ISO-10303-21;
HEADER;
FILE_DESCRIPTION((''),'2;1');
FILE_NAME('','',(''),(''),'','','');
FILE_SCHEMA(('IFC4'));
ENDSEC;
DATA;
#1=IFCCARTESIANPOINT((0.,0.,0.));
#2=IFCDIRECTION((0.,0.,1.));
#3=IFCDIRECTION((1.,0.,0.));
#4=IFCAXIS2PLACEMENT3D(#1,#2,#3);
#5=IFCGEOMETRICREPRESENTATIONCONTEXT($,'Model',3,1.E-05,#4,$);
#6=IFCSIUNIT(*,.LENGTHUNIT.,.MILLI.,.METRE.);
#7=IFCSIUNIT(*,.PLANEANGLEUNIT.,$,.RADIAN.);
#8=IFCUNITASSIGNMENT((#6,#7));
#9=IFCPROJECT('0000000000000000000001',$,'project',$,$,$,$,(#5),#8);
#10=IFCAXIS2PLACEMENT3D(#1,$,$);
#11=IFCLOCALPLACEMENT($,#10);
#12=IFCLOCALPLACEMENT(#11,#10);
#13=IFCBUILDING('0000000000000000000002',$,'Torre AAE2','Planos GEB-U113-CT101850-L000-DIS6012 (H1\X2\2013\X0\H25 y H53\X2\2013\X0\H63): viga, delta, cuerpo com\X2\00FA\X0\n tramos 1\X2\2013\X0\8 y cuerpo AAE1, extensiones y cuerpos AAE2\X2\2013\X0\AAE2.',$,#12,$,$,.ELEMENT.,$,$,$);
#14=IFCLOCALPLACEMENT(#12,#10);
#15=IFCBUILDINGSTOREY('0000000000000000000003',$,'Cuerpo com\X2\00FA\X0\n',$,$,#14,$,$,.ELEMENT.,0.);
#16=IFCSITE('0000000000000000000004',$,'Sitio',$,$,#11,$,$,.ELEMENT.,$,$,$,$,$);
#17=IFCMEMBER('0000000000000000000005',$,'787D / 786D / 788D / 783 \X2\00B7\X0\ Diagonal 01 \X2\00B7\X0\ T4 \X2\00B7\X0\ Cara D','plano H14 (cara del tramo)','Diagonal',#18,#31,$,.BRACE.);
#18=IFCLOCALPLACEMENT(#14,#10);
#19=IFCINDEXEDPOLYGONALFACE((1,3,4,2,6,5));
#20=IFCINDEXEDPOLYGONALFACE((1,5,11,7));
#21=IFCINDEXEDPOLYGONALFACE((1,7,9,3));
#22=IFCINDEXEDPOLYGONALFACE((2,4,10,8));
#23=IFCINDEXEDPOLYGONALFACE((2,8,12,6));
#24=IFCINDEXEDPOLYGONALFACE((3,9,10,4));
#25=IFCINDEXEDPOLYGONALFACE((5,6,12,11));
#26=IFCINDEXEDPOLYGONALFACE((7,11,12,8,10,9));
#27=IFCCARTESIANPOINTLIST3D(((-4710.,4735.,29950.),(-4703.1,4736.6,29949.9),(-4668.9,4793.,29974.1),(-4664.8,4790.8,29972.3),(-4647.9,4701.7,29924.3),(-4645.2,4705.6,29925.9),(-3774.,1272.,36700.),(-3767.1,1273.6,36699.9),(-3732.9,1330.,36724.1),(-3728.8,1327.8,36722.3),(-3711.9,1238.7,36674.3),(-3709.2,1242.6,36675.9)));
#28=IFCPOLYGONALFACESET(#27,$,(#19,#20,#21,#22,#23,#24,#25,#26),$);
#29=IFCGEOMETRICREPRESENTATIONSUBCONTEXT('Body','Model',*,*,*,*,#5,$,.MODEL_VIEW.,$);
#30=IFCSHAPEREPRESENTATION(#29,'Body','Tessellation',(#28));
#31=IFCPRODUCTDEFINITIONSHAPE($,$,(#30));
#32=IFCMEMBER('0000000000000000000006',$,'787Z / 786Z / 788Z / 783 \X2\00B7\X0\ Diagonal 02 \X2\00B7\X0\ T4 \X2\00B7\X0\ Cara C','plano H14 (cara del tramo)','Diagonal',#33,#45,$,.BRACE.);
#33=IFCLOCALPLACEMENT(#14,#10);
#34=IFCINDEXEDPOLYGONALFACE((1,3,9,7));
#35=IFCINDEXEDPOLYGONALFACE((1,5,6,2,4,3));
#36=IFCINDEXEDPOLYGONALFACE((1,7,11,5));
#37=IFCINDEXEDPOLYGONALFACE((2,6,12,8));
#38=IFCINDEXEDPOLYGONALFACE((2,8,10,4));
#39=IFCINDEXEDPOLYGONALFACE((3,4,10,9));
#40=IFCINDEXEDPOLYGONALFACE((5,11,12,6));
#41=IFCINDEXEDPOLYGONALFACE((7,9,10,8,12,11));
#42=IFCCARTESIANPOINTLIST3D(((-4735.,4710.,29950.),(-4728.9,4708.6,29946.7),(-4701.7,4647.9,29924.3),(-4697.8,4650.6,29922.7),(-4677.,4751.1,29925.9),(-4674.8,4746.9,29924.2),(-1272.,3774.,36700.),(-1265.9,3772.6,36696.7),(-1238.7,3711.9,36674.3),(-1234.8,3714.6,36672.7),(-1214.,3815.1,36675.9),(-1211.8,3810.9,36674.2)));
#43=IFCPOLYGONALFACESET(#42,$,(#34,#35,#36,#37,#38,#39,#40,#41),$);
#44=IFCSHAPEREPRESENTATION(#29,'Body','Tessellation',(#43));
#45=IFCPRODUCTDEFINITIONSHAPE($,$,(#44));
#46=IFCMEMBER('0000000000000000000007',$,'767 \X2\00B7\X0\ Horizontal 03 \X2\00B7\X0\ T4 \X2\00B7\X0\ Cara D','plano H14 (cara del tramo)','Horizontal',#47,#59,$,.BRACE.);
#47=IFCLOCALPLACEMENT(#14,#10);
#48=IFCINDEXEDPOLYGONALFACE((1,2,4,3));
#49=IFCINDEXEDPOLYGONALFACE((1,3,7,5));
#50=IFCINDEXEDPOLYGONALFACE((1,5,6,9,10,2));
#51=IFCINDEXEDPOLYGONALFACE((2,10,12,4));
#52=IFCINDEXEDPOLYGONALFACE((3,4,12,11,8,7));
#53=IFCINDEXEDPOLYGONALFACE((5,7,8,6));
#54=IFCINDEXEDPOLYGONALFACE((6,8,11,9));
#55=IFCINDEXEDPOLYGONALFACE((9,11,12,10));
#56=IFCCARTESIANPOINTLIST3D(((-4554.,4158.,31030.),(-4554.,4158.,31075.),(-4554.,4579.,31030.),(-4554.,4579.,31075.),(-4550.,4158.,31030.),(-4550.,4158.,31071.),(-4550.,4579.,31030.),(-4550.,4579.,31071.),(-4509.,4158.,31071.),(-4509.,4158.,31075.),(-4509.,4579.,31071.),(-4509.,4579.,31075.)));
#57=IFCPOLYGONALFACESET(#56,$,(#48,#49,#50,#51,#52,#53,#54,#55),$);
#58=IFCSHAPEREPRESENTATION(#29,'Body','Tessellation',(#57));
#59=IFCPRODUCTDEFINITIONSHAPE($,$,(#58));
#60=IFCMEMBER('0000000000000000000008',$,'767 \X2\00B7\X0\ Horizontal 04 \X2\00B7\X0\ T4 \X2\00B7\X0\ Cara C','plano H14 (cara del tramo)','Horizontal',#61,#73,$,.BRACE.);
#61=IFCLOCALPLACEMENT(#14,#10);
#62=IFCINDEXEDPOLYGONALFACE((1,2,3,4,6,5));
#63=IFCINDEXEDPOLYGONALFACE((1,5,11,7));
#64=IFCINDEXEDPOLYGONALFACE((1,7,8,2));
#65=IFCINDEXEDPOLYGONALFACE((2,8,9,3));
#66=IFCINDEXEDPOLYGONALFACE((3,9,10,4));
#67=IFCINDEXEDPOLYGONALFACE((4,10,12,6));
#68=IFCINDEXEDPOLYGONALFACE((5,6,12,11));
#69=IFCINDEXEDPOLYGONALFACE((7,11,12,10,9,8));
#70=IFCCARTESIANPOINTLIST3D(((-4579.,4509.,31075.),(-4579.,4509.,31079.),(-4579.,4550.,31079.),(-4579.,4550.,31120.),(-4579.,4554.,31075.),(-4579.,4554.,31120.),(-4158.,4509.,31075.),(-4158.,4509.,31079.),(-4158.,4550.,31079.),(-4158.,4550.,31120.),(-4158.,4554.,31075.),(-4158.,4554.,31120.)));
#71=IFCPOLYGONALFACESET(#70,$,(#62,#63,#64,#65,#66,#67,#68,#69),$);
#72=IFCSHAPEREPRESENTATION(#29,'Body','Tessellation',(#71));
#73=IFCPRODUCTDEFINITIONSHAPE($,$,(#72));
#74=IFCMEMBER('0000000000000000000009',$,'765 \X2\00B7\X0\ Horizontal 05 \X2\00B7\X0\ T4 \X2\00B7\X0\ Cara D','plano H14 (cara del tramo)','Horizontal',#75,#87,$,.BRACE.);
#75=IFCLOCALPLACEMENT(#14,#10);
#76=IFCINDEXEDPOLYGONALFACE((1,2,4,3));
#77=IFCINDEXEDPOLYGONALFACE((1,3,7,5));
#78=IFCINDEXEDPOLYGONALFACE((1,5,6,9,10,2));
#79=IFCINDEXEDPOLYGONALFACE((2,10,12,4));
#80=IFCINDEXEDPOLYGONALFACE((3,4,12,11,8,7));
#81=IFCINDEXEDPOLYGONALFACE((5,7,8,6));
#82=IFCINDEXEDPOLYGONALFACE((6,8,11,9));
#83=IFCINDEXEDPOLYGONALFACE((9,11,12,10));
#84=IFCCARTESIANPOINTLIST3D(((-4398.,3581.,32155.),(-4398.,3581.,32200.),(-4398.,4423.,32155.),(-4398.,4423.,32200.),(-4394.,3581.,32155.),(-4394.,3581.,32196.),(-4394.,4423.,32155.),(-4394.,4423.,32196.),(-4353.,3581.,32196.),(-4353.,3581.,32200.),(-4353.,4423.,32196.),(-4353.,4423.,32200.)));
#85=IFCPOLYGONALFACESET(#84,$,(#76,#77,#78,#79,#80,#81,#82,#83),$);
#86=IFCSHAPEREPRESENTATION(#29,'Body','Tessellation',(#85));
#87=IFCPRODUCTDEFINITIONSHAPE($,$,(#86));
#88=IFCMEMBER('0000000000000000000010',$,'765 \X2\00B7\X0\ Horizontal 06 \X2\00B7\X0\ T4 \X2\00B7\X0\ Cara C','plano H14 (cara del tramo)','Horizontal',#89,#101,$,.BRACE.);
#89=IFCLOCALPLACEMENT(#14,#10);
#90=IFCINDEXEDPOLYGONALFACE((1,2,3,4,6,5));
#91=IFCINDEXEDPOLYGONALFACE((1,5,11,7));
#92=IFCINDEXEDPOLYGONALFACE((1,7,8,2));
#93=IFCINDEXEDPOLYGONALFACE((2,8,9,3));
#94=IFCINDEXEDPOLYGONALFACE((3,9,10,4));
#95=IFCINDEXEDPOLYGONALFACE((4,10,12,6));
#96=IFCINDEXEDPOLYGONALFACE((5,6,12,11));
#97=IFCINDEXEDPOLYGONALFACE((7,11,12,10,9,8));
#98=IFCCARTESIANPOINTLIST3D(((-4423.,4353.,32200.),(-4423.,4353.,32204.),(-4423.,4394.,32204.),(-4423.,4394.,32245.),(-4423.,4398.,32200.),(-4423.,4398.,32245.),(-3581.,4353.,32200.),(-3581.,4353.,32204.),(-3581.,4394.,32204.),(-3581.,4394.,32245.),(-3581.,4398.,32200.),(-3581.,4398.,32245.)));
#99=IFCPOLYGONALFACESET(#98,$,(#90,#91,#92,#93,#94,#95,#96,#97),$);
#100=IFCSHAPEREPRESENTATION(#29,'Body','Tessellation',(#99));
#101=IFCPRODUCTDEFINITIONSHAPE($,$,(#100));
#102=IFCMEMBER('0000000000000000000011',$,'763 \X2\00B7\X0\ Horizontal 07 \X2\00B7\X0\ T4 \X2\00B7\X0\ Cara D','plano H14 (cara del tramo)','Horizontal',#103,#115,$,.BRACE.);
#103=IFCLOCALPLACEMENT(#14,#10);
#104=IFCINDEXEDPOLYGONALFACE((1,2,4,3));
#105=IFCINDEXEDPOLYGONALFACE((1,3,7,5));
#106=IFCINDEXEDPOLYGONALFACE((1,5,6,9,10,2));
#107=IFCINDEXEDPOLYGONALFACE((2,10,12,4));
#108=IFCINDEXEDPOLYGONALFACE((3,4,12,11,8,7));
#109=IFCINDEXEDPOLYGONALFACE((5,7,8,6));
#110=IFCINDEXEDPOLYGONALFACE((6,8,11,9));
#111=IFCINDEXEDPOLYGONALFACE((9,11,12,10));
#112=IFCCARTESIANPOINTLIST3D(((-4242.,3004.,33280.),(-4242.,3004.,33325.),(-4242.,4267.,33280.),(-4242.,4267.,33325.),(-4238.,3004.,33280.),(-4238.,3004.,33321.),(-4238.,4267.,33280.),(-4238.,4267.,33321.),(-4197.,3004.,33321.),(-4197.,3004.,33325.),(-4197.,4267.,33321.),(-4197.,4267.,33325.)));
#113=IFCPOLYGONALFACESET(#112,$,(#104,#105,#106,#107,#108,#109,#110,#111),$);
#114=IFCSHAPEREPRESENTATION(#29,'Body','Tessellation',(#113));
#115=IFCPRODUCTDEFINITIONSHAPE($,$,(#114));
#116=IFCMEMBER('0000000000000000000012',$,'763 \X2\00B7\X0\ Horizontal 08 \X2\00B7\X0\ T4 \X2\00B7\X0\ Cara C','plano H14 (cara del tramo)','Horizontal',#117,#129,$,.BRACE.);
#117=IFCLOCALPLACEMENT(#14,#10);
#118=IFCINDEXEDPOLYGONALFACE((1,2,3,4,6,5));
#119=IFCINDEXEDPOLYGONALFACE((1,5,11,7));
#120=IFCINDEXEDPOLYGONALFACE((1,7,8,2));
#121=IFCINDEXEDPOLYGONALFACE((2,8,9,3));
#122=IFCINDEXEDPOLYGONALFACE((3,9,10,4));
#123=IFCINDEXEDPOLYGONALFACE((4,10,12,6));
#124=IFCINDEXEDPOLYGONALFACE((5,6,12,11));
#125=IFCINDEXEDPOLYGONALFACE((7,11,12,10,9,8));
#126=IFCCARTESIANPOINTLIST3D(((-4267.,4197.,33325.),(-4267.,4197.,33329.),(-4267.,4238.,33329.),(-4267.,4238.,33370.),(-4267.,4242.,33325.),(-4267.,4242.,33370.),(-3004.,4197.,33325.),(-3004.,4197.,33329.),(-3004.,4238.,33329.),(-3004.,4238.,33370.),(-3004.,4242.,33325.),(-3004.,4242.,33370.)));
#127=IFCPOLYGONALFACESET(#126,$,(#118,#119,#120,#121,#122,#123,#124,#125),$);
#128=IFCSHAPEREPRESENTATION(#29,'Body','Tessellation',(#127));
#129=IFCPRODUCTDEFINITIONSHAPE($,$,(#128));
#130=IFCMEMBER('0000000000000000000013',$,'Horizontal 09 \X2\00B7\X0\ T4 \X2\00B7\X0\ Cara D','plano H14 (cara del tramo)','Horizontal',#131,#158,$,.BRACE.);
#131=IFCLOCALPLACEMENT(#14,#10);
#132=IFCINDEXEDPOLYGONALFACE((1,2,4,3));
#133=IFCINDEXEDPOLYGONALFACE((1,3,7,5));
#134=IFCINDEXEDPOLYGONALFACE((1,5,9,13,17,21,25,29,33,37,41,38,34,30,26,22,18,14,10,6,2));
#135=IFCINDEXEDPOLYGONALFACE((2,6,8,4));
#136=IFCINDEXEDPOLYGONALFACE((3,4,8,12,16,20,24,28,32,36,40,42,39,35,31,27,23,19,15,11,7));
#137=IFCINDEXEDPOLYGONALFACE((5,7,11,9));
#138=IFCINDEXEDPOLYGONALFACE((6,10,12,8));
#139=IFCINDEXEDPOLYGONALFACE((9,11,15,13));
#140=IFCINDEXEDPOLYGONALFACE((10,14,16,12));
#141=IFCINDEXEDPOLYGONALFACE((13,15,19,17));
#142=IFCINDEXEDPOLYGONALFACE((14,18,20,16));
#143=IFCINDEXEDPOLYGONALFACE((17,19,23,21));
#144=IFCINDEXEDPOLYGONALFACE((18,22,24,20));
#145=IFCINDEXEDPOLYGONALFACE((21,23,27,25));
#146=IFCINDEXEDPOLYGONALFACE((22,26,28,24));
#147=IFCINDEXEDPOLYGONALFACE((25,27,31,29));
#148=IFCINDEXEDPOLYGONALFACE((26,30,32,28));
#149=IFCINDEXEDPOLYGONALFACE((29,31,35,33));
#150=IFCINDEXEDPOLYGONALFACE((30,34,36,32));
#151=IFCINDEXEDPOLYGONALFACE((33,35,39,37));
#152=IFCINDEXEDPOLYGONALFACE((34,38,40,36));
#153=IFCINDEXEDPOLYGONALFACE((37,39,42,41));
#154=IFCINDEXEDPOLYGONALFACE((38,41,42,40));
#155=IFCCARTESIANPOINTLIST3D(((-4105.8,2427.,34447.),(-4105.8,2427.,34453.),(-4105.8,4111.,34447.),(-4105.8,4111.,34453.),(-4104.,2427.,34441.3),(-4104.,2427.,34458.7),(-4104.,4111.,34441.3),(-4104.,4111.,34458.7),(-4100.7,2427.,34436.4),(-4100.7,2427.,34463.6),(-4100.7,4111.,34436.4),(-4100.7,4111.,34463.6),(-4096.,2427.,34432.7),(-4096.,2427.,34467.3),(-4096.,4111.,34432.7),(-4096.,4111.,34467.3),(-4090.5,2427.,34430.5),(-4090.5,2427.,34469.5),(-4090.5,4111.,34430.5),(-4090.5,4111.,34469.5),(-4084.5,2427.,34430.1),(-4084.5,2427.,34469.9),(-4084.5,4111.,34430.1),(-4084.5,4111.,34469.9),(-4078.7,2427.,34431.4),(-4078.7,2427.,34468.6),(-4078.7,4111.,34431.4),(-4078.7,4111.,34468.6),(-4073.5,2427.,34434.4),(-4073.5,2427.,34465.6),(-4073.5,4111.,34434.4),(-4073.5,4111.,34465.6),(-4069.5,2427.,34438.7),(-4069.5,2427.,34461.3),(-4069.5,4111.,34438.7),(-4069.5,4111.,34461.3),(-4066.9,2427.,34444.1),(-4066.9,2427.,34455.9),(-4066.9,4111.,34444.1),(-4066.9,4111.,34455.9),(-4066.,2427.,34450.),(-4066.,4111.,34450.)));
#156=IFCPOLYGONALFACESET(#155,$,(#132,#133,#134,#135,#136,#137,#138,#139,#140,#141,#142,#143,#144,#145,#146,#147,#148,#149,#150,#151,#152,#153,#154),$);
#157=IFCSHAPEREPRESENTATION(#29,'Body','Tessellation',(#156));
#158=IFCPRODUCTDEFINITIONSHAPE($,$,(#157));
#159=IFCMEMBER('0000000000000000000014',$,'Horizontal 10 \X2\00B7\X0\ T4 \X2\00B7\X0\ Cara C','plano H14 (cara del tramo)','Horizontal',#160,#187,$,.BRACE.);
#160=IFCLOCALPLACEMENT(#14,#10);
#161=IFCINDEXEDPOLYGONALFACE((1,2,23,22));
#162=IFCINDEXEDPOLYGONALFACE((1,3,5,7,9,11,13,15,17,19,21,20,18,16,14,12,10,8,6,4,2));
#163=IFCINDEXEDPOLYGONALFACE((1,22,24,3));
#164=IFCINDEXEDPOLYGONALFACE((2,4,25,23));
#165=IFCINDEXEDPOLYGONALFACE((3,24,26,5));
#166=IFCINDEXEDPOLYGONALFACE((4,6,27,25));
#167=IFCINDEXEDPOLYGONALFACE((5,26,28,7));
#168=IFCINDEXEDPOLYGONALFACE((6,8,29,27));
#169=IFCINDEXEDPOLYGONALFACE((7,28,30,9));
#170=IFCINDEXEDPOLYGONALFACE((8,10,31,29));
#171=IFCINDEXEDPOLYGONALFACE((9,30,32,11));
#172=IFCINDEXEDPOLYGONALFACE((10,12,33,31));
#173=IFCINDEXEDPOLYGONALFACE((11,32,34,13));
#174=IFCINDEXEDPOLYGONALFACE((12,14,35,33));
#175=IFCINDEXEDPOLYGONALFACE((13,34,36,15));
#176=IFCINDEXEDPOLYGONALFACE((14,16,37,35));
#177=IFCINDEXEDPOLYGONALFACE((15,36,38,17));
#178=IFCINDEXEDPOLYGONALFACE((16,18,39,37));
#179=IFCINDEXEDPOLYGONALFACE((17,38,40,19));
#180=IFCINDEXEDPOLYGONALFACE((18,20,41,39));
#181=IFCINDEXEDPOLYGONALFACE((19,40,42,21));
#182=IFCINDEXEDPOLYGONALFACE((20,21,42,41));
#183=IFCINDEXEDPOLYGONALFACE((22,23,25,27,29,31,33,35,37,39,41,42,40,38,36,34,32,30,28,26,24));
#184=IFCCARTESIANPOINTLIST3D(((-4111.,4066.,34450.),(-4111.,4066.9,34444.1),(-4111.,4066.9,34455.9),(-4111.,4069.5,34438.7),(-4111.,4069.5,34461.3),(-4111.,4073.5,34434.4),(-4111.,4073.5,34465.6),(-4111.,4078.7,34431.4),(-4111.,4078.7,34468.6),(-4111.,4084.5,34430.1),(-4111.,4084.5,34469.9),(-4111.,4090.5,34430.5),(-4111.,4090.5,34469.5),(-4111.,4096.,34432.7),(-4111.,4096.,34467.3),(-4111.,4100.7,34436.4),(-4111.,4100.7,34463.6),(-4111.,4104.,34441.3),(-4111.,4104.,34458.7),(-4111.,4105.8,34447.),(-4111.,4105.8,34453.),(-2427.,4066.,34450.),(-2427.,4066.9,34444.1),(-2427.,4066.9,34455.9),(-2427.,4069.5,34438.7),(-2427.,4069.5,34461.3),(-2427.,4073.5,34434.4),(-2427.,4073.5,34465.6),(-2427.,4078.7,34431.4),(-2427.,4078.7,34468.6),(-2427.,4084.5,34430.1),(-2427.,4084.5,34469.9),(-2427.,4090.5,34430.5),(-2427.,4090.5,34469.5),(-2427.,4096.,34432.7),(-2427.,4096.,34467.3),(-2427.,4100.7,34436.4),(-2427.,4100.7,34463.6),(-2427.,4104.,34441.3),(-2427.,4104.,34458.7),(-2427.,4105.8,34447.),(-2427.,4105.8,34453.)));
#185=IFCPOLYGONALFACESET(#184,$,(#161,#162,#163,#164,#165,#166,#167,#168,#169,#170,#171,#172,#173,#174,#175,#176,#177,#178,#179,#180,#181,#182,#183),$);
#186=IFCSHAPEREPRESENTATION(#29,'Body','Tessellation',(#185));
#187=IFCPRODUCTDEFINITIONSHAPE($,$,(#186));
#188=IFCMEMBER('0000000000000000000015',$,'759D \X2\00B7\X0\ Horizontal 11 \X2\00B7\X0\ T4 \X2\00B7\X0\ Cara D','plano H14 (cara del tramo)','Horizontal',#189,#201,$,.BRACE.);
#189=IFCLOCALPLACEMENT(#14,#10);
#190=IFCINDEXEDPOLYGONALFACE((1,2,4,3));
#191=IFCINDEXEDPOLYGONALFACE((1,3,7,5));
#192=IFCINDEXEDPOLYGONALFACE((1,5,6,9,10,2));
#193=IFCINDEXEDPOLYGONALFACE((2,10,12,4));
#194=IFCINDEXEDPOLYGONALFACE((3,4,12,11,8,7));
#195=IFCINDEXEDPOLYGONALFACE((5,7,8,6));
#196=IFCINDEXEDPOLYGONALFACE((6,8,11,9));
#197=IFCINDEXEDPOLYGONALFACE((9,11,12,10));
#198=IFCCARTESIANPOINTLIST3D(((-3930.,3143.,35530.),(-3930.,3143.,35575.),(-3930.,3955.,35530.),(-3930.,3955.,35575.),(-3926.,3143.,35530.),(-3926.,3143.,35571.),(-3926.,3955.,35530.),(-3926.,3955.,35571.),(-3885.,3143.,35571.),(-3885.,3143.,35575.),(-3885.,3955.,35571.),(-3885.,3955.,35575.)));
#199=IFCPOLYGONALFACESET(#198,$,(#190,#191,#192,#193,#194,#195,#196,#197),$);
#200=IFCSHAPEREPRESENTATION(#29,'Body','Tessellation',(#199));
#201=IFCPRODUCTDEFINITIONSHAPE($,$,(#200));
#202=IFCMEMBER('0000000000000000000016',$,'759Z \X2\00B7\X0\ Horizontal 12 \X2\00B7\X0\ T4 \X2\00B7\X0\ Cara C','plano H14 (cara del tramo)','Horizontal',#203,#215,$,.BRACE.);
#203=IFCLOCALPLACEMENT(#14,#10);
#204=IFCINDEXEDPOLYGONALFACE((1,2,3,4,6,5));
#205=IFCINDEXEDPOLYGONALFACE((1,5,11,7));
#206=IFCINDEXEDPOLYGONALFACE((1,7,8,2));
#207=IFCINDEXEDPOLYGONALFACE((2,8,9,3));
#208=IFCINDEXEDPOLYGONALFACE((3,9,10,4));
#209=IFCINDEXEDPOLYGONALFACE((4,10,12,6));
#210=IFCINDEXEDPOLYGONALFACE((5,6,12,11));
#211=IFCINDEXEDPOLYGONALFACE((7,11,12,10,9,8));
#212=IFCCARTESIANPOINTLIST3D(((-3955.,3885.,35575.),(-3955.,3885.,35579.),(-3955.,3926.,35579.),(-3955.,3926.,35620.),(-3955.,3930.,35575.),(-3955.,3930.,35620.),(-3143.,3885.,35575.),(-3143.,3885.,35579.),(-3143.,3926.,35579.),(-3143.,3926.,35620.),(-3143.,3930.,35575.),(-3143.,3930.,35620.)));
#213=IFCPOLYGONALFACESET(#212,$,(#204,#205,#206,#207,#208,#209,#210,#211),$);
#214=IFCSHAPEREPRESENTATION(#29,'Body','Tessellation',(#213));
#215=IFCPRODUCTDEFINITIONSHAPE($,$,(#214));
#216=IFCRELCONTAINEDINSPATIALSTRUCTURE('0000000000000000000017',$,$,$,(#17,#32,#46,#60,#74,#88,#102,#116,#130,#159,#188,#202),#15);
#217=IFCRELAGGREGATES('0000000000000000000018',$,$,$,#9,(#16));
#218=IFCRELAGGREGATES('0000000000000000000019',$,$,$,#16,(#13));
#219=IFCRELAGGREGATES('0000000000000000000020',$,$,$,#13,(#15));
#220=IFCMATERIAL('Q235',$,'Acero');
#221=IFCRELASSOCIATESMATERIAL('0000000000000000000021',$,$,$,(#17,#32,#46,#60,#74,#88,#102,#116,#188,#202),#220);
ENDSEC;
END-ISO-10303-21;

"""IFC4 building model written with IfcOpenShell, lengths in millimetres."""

from ifc_helpers import new_model, si_unit, frame, frame_2d, origin, origin_with_axes, place, context, subcontext, project, spatial, circle, l_section, extrude, material, element, save


model = new_model("IFC4")

# Units and contexts
model_context = context("Model", 3, precision=1e-05, world=origin_with_axes())
body_context = subcontext(model_context, "Body", "Model", "MODEL_VIEW")
ifc_project = project(units=[si_unit("LENGTHUNIT", "METRE", prefix="MILLI"), si_unit("PLANEANGLEUNIT", "RADIAN")], contexts=[model_context])

# Site, building, storey
site_placement = place(None, origin())
site = spatial("IfcSite", under=ifc_project, at=site_placement, Name="Sitio", CompositionType="ELEMENT")
building_placement = place(site_placement, origin())
building = spatial("IfcBuilding", under=site, at=building_placement, Name="Torre AAE2", Description="Planos GEB-U113-CT101850-L000-DIS6012 (H1–H25 y H53–H63): viga, delta, cuerpo común tramos 1–8 y cuerpo AAE1, extensiones y cuerpos AAE2–AAE2.", CompositionType="ELEMENT")
storey_placement = place(building_placement, origin())
storey = spatial("IfcBuildingStorey", under=building, at=storey_placement, Name="Cuerpo común", CompositionType="ELEMENT", Elevation=0.0)

# Members
ifc_material_1 = material(Name="Q235", Category="Acero")
for number, where, z_axis, x_axis, name in (
    (1, (-4710.0, 4735.0, 29950.0), (0.122449, -0.453034, 0.883044), (0.827907, -0.444053, -0.342619), "787D / 786D / 788D / 783 · Diagonal 01 · T4 · Cara D"),
    (2, (-4735.0, 4710.0, 29950.0), (0.453034, -0.122449, 0.883044), (0.444053, -0.827907, -0.342619), "787Z / 786Z / 788Z / 783 · Diagonal 02 · T4 · Cara C"),
):
    element("IfcMember", number, at=place(storey_placement, frame(where, z_axis=z_axis, x_axis=x_axis)), inside=storey, material=ifc_material_1, Name=name, Description="plano H14 (cara del tramo)", ObjectType="Diagonal", PredefinedType="BRACE", context=body_context, shape_type="SweptSolid", body=[
        extrude(l_section(Depth=75.0, Width=75.0, Thickness=5.0, at=frame_2d((37.5, 37.5))), None, (0.0, 0.0, 1.0), 7644.0),
    ])
for number, where, z_axis, x_axis, name in (
    (3, (-4554.0, 4158.0, 31075.0), (0.0, 1.0, 0.0), (1.0, 0.0, 0.0), "767 · Horizontal 03 · T4 · Cara D"),
    (4, (-4158.0, 4554.0, 31075.0), (-1.0, 0.0, 0.0), (0.0, -1.0, 0.0), "767 · Horizontal 04 · T4 · Cara C"),
):
    element("IfcMember", number, at=place(storey_placement, frame(where, z_axis=z_axis, x_axis=x_axis)), inside=storey, material=ifc_material_1, Name=name, Description="plano H14 (cara del tramo)", ObjectType="Horizontal", PredefinedType="BRACE", context=body_context, shape_type="SweptSolid", body=[
        extrude(l_section(Depth=45.0, Width=45.0, Thickness=4.0, at=frame_2d((22.5, 22.5))), None, (0.0, 0.0, 1.0), 421.0),
    ])
for number, where, z_axis, x_axis, name in (
    (5, (-4398.0, 3581.0, 32200.0), (0.0, 1.0, 0.0), (1.0, 0.0, 0.0), "765 · Horizontal 05 · T4 · Cara D"),
    (6, (-3581.0, 4398.0, 32200.0), (-1.0, 0.0, 0.0), (0.0, -1.0, 0.0), "765 · Horizontal 06 · T4 · Cara C"),
):
    element("IfcMember", number, at=place(storey_placement, frame(where, z_axis=z_axis, x_axis=x_axis)), inside=storey, material=ifc_material_1, Name=name, Description="plano H14 (cara del tramo)", ObjectType="Horizontal", PredefinedType="BRACE", context=body_context, shape_type="SweptSolid", body=[
        extrude(l_section(Depth=45.0, Width=45.0, Thickness=4.0, at=frame_2d((22.5, 22.5))), None, (0.0, 0.0, 1.0), 842.0),
    ])
for number, where, z_axis, x_axis, name in (
    (7, (-4242.0, 3004.0, 33325.0), (0.0, 1.0, 0.0), (1.0, 0.0, 0.0), "763 · Horizontal 07 · T4 · Cara D"),
    (8, (-3004.0, 4242.0, 33325.0), (-1.0, 0.0, 0.0), (0.0, -1.0, 0.0), "763 · Horizontal 08 · T4 · Cara C"),
):
    element("IfcMember", number, at=place(storey_placement, frame(where, z_axis=z_axis, x_axis=x_axis)), inside=storey, material=ifc_material_1, Name=name, Description="plano H14 (cara del tramo)", ObjectType="Horizontal", PredefinedType="BRACE", context=body_context, shape_type="SweptSolid", body=[
        extrude(l_section(Depth=45.0, Width=45.0, Thickness=4.0, at=frame_2d((22.5, 22.5))), None, (0.0, 0.0, 1.0), 1263.0),
    ])
for number, where, z_axis, x_axis, name in (
    (9, (-4086.0, 2427.0, 34450.0), (0.0, 1.0, 0.0), (1.0, 0.0, 0.0), "Horizontal 09 · T4 · Cara D"),
    (10, (-2427.0, 4086.0, 34450.0), (-1.0, 0.0, 0.0), (0.0, -1.0, 0.0), "Horizontal 10 · T4 · Cara C"),
):
    element("IfcMember", number, at=place(storey_placement, frame(where, z_axis=z_axis, x_axis=x_axis)), inside=storey, Name=name, Description="plano H14 (cara del tramo)", ObjectType="Horizontal", PredefinedType="BRACE", context=body_context, shape_type="SweptSolid", body=[
        extrude(circle(Radius=20.0), None, (0.0, 0.0, 1.0), 1684.0),
    ])
for number, where, z_axis, x_axis, name in (
    (11, (-3930.0, 3143.0, 35575.0), (0.0, 1.0, 0.0), (1.0, 0.0, 0.0), "759D · Horizontal 11 · T4 · Cara D"),
    (12, (-3143.0, 3930.0, 35575.0), (-1.0, 0.0, 0.0), (0.0, -1.0, 0.0), "759Z · Horizontal 12 · T4 · Cara C"),
):
    element("IfcMember", number, at=place(storey_placement, frame(where, z_axis=z_axis, x_axis=x_axis)), inside=storey, material=ifc_material_1, Name=name, Description="plano H14 (cara del tramo)", ObjectType="Horizontal", PredefinedType="BRACE", context=body_context, shape_type="SweptSolid", body=[
        extrude(l_section(Depth=45.0, Width=45.0, Thickness=4.0, at=frame_2d((22.5, 22.5))), None, (0.0, 0.0, 1.0), 812.0),
    ])

save(model, "model.ifc")
